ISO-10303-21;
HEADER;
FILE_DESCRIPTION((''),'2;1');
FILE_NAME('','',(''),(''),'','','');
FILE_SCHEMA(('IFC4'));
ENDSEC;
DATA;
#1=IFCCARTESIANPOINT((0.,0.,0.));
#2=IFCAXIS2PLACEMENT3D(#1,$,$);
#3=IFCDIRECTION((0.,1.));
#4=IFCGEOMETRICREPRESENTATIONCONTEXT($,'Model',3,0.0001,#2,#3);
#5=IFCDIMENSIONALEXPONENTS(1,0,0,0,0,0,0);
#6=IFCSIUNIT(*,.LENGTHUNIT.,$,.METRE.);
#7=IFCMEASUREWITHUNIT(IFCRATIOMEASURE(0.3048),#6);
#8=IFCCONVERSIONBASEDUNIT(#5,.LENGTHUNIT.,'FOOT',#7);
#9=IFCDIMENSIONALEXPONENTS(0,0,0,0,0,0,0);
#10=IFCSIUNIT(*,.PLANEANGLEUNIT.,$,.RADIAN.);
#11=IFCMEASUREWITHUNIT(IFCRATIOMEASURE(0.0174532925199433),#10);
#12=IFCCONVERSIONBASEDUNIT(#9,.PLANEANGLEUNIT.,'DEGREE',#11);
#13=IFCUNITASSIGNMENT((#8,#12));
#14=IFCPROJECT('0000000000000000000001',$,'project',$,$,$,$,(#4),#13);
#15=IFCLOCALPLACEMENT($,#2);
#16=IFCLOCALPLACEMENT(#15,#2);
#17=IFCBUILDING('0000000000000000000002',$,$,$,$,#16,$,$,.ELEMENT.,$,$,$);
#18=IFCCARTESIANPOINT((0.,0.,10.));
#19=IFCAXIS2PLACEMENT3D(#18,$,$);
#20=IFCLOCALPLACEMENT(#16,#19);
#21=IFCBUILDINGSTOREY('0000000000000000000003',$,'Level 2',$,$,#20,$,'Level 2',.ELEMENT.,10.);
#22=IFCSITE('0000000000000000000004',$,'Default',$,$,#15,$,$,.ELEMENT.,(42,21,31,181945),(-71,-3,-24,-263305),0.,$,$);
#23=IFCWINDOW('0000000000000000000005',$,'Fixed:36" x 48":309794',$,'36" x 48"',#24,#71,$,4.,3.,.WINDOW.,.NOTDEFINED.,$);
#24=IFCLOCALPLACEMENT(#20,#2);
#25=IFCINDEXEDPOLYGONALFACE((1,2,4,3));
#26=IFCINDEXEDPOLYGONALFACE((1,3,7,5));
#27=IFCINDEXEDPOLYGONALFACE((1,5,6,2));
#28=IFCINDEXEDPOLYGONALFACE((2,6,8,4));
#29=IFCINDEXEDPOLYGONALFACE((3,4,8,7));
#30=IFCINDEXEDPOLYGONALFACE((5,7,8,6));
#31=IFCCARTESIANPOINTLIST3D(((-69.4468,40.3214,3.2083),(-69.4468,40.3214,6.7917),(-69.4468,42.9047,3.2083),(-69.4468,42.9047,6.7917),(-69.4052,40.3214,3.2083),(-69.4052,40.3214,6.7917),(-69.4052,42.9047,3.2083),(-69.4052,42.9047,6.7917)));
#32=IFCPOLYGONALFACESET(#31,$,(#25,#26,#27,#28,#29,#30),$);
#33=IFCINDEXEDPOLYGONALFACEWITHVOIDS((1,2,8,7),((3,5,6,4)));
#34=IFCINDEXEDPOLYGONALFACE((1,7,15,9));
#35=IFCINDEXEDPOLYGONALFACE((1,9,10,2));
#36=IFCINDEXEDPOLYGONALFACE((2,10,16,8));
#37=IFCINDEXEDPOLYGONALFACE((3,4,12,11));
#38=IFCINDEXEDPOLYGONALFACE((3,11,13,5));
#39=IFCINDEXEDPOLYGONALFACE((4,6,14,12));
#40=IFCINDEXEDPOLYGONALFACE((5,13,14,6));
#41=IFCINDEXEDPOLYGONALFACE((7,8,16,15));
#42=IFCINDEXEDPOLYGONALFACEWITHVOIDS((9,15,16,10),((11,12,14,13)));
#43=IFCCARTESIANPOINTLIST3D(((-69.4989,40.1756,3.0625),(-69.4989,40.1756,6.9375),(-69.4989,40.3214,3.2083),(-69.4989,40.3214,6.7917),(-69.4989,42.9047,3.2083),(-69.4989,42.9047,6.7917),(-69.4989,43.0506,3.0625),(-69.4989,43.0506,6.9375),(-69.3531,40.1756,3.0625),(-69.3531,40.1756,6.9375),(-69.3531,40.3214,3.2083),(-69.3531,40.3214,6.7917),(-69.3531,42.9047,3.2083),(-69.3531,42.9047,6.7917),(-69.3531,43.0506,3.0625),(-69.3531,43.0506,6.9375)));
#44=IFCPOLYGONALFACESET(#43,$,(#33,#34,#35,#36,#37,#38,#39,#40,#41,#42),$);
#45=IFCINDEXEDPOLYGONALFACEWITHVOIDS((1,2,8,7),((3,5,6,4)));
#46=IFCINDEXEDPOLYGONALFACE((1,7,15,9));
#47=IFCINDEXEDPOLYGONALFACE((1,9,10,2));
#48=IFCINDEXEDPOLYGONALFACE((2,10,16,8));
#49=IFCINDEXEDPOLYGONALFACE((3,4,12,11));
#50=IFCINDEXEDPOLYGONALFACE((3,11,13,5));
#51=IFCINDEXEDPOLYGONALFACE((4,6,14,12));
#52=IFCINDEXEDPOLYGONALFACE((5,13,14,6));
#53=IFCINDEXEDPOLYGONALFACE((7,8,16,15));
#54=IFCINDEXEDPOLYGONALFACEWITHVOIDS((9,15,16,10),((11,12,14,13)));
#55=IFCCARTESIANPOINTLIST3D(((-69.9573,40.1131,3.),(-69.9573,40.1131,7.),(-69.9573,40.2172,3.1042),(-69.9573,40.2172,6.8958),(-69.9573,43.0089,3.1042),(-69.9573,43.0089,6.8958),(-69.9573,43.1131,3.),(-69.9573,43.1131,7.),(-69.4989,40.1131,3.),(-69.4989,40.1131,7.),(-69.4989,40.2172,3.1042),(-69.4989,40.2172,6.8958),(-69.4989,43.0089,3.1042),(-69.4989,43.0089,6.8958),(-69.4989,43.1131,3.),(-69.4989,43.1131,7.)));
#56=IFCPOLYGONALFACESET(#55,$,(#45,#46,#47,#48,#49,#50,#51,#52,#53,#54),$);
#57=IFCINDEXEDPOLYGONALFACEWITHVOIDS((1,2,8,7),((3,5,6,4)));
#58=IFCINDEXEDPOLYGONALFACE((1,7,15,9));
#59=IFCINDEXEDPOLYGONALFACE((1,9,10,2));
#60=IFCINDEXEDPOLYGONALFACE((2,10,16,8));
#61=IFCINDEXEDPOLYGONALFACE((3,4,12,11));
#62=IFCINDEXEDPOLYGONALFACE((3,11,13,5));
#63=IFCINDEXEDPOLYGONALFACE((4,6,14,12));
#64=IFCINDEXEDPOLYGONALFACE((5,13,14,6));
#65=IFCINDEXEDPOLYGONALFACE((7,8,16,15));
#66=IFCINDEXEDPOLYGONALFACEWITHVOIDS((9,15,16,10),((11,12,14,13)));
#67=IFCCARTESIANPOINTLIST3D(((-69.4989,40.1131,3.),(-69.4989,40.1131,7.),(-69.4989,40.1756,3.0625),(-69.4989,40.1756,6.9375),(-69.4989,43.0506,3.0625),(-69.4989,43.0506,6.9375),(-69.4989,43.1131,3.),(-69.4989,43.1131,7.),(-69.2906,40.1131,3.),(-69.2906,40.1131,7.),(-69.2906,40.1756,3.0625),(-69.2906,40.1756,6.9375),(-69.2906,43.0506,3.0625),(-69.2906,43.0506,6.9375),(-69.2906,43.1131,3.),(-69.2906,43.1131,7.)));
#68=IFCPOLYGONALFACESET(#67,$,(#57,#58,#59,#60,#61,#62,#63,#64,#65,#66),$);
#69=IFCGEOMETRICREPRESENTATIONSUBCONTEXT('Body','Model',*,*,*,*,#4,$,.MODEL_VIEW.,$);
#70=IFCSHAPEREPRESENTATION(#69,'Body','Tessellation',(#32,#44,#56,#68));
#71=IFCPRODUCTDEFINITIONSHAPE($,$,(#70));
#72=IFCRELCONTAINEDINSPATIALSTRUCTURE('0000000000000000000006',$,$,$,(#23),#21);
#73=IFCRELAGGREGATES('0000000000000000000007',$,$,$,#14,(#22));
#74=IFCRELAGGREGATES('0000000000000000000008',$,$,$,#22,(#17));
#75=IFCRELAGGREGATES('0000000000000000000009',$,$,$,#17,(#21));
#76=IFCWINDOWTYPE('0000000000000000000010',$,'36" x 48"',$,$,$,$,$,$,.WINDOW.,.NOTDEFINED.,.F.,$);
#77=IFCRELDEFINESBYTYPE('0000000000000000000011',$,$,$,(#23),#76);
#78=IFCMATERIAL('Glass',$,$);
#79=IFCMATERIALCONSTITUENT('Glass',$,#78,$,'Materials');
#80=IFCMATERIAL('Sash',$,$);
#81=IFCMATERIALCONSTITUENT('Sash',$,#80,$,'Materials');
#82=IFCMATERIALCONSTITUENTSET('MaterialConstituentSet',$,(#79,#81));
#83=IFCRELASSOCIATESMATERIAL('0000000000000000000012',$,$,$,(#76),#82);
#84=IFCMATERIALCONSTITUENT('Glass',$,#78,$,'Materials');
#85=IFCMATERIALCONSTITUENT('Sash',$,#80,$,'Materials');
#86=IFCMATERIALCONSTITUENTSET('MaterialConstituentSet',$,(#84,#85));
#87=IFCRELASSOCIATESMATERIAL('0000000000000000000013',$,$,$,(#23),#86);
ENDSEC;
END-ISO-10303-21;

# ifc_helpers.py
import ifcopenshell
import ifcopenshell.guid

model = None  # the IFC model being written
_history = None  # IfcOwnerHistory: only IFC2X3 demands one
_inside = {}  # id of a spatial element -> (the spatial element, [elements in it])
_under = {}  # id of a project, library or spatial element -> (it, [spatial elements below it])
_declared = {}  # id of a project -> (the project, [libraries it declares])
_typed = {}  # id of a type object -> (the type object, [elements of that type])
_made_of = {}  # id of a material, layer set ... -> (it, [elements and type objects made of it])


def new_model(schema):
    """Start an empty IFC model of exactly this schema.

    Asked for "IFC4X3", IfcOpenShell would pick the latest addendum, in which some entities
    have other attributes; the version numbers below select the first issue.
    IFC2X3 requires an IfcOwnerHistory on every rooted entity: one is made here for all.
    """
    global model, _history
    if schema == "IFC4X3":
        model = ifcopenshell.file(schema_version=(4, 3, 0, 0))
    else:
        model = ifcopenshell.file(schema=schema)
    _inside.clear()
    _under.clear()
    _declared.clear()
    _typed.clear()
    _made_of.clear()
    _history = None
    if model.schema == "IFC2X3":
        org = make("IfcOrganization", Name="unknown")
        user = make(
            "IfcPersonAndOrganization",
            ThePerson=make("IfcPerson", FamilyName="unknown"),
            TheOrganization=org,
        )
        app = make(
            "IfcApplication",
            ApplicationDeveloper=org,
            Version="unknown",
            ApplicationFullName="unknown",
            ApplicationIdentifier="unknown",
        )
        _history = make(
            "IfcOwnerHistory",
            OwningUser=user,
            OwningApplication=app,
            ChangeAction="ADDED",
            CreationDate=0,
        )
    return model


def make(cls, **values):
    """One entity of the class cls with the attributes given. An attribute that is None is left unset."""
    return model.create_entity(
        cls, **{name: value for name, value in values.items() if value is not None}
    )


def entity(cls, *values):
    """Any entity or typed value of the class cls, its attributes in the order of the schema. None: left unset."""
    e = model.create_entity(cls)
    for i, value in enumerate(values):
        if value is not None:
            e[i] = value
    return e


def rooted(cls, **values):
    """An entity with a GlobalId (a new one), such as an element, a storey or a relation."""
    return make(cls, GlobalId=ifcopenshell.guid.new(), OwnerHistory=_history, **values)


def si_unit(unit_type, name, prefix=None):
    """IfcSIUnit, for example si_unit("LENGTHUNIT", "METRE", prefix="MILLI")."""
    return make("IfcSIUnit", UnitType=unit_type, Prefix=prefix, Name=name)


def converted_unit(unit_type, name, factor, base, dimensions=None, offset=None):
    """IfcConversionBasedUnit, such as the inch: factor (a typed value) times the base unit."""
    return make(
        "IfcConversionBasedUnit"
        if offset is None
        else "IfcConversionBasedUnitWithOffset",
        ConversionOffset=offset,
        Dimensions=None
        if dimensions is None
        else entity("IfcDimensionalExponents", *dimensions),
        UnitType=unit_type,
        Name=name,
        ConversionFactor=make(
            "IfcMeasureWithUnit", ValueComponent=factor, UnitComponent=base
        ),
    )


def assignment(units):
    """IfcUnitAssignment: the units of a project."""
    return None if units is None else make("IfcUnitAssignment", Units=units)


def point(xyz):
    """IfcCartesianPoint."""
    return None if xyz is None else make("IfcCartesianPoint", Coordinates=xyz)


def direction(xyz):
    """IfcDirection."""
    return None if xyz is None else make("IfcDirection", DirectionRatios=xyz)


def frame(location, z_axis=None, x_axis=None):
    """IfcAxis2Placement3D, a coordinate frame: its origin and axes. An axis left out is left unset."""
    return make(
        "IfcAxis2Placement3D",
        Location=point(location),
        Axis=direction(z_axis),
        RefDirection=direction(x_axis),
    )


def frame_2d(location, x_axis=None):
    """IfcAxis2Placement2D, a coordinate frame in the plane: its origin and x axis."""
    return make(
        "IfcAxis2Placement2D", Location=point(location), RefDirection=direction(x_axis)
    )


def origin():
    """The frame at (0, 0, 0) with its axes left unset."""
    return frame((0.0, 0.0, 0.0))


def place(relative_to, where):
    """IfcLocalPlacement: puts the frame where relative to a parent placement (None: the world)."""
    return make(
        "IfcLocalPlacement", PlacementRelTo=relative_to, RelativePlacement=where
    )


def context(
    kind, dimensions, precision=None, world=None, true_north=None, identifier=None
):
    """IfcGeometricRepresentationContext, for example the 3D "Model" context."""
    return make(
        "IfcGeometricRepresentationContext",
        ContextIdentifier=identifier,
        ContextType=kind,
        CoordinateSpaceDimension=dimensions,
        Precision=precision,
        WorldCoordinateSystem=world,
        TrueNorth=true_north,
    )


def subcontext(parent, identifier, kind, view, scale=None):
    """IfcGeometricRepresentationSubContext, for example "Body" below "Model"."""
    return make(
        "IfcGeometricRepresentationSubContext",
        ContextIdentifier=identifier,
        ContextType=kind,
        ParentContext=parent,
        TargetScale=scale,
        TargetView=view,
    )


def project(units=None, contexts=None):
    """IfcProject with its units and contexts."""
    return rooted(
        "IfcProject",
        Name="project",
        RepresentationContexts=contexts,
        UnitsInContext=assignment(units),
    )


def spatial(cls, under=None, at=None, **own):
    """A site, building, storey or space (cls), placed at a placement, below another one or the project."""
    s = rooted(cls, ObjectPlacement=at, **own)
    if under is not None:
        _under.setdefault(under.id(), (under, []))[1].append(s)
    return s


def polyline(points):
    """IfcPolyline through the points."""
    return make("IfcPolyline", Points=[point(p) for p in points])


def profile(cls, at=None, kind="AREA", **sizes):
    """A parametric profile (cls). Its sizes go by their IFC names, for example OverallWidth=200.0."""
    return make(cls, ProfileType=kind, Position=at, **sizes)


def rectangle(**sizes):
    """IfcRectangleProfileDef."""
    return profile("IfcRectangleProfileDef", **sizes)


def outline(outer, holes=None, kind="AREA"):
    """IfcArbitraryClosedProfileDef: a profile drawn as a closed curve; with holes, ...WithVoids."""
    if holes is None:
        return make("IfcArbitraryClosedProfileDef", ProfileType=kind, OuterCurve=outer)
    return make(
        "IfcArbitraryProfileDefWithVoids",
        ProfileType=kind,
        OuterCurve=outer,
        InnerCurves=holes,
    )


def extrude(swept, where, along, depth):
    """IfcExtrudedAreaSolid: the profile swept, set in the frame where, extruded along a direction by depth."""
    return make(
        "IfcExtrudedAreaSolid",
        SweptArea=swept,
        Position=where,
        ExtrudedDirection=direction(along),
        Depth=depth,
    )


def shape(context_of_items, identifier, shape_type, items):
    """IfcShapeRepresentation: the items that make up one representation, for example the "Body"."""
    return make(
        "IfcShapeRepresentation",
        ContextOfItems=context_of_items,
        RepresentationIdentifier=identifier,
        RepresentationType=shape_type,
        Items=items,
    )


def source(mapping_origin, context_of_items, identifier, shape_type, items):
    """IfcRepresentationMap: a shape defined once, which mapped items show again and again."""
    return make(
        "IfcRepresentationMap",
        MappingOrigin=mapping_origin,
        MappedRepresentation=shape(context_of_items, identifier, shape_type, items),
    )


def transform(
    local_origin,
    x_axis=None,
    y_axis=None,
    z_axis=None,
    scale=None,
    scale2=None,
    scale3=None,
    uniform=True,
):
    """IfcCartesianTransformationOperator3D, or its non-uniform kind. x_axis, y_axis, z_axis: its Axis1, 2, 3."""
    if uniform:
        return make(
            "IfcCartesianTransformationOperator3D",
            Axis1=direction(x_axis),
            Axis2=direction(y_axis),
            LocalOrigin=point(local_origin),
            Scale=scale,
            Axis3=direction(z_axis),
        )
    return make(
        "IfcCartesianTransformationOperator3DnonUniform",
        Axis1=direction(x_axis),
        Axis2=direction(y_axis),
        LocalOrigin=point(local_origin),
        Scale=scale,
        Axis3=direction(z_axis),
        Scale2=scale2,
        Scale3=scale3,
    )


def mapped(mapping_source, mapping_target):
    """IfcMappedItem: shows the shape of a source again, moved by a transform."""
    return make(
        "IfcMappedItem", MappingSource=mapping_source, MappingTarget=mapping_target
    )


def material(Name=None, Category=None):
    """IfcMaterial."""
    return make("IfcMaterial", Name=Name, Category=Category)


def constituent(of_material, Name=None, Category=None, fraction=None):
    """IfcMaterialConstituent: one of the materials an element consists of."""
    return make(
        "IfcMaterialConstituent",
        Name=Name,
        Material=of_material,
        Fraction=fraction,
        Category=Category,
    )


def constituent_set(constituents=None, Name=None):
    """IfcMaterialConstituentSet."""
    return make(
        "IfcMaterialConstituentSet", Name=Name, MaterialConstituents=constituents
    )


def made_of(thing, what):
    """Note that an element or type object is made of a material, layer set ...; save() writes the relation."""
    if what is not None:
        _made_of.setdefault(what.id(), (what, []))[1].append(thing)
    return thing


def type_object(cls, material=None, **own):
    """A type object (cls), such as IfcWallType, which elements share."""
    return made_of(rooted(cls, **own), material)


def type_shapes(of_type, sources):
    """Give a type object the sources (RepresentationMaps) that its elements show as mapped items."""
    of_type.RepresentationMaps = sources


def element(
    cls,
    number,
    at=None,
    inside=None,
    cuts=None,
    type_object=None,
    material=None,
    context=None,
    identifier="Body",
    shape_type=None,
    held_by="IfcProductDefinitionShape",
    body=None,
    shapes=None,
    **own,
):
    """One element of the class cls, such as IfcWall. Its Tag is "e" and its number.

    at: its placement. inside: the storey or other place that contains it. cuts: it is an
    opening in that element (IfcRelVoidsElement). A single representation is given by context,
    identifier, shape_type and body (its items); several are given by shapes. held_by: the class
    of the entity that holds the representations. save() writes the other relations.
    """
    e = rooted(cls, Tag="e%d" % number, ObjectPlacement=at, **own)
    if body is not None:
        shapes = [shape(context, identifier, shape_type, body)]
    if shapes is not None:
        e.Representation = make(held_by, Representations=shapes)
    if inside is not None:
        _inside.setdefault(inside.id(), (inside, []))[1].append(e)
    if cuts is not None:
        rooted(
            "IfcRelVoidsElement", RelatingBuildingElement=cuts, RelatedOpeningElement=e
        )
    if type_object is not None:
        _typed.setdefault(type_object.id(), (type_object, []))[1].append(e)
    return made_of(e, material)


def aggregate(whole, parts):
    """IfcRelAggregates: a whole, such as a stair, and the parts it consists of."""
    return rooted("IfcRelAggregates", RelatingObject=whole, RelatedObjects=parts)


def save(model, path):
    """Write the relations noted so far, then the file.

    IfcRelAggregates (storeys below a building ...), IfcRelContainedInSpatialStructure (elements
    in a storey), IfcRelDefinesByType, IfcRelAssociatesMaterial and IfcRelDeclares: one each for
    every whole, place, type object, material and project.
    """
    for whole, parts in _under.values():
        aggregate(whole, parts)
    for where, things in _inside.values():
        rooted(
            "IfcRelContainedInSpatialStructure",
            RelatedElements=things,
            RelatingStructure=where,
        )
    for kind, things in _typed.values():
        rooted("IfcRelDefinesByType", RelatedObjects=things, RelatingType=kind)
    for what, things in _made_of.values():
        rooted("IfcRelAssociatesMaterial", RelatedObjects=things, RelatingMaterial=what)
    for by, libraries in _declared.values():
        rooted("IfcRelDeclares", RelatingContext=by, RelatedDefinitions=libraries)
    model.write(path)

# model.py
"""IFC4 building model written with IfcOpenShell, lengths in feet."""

from ifc_helpers import new_model, entity, si_unit, converted_unit, direction, frame, frame_2d, origin, place, context, subcontext, project, spatial, polyline, rectangle, outline, extrude, source, transform, mapped, material, constituent, constituent_set, type_object, type_shapes, element, save


model = new_model("IFC4")

# Units and contexts
model_context = context("Model", 3, precision=0.0001, world=origin(), true_north=direction((0.0, 1.0)))
body_context = subcontext(model_context, "Body", "Model", "MODEL_VIEW")
ifc_project = project(units=[converted_unit("LENGTHUNIT", "FOOT", entity("IfcRatioMeasure", 0.3048), si_unit("LENGTHUNIT", "METRE"), dimensions=[1, 0, 0, 0, 0, 0, 0]), converted_unit("PLANEANGLEUNIT", "DEGREE", entity("IfcRatioMeasure", 0.0174532925199433), si_unit("PLANEANGLEUNIT", "RADIAN"), dimensions=[0, 0, 0, 0, 0, 0, 0])], contexts=[model_context])

# Site, building, storey
site_placement = place(None, origin())
site = spatial("IfcSite", under=ifc_project, at=site_placement, Name="Default", CompositionType="ELEMENT", RefLatitude=(42, 21, 31, 181945), RefLongitude=(-71, -3, -24, -263305), RefElevation=0.0)
building_placement = place(site_placement, origin())
building = spatial("IfcBuilding", under=site, at=building_placement, CompositionType="ELEMENT")
storey_placement = place(building_placement, frame((0.0, 0.0, 10.0)))
storey = spatial("IfcBuildingStorey", under=building, at=storey_placement, Name="Level 2", LongName="Level 2", CompositionType="ELEMENT", Elevation=10.0)

# Shared definitions
placement_1 = place(storey_placement, frame((-69.6239, 19.7797, 0.0), z_axis=(0.0, 0.0, 1.0), x_axis=(0.0, 1.0, 0.0)))

# Window
ifc_material_1 = material(Name="Glass")
ifc_constituent_1 = constituent(ifc_material_1, Name="Glass", Category="Materials")
ifc_material_2 = material(Name="Sash")
ifc_constituent_2 = constituent(ifc_material_2, Name="Sash", Category="Materials")
ifc_constituent_set_1 = constituent_set(constituents=[ifc_constituent_1, ifc_constituent_2], Name="MaterialConstituentSet")
ifc_constituent_3 = constituent(ifc_material_1, Name="Glass", Category="Materials")
ifc_constituent_4 = constituent(ifc_material_2, Name="Sash", Category="Materials")
ifc_constituent_set_2 = constituent_set(constituents=[ifc_constituent_3, ifc_constituent_4], Name="MaterialConstituentSet")
window_type = type_object("IfcWindowType", Name="36\" x 48\"", ParameterTakesPrecedence=False, PartitioningType="NOTDEFINED", PredefinedType="WINDOW", material=ifc_constituent_set_2)
shared_shape = source(origin(), body_context, "Body", "SweptSolid", [
    extrude(rectangle(XDim=0.0417, YDim=2.5833, at=frame_2d((0.0, 0.0), x_axis=(1.0, 0.0))), frame((1.5, 0.5312, 0.2083), z_axis=(0.0, 0.0, 1.0), x_axis=(0.0, 1.0, 0.0)), (0.0, 0.0, 1.0), 3.5833),
    extrude(outline(polyline([(-1.4375, -1.9375), (1.4375, -1.9375), (1.4375, 1.9375), (-1.4375, 1.9375), (-1.4375, -1.9375)]), holes=[polyline([(-1.2917, -1.7917), (-1.2917, 1.7917), (1.2917, 1.7917), (1.2917, -1.7917), (-1.2917, -1.7917)])]), frame((1.5, 0.4583, 2.0), z_axis=(0.0, 1.0, 0.0), x_axis=(1.0, 0.0, 0.0)), (0.0, 0.0, 1.0), 0.1458),
    extrude(outline(polyline([(-1.5, -2.0), (1.5, -2.0), (1.5, 2.0), (-1.5, 2.0), (-1.5, -2.0)]), holes=[polyline([(-1.3958, -1.8958), (-1.3958, 1.8958), (1.3958, 1.8958), (1.3958, -1.8958), (-1.3958, -1.8958)])]), frame((1.5, 0.0, 2.0), z_axis=(0.0, 1.0, 0.0), x_axis=(1.0, 0.0, 0.0)), (0.0, 0.0, 1.0), 0.4583),
    extrude(outline(polyline([(-2.0, -1.5), (2.0, -1.5), (2.0, 1.5), (-2.0, 1.5), (-2.0, -1.5)]), holes=[polyline([(-1.9375, -1.4375), (-1.9375, 1.4375), (1.9375, 1.4375), (1.9375, -1.4375), (-1.9375, -1.4375)])]), frame((1.5, 0.4583, 2.0), z_axis=(0.0, 1.0, 0.0), x_axis=(0.0, 0.0, -1.0)), (0.0, 0.0, 1.0), 0.2083),
])
type_shapes(window_type, [shared_shape])
placement_2 = place(placement_1, frame((23.3333, 0.3333, 3.0)))
window_placement = place(placement_2, frame((0.0, 0.0, 0.0), z_axis=(0.0, 0.0, 1.0), x_axis=(-1.0, 0.0, 0.0)))
element("IfcWindow", 1, at=window_placement, inside=storey, type_object=window_type, material=ifc_constituent_set_1, Name="Fixed:36\" x 48\":309794", ObjectType="36\" x 48\"", OverallHeight=4.0, OverallWidth=3.0, PartitioningType="NOTDEFINED", PredefinedType="WINDOW", context=body_context, shape_type="MappedRepresentation", body=[
    mapped(shared_shape, transform((0.0, 0.0, 0.0), scale=1.0)),
])

save(model, "model.ifc")
